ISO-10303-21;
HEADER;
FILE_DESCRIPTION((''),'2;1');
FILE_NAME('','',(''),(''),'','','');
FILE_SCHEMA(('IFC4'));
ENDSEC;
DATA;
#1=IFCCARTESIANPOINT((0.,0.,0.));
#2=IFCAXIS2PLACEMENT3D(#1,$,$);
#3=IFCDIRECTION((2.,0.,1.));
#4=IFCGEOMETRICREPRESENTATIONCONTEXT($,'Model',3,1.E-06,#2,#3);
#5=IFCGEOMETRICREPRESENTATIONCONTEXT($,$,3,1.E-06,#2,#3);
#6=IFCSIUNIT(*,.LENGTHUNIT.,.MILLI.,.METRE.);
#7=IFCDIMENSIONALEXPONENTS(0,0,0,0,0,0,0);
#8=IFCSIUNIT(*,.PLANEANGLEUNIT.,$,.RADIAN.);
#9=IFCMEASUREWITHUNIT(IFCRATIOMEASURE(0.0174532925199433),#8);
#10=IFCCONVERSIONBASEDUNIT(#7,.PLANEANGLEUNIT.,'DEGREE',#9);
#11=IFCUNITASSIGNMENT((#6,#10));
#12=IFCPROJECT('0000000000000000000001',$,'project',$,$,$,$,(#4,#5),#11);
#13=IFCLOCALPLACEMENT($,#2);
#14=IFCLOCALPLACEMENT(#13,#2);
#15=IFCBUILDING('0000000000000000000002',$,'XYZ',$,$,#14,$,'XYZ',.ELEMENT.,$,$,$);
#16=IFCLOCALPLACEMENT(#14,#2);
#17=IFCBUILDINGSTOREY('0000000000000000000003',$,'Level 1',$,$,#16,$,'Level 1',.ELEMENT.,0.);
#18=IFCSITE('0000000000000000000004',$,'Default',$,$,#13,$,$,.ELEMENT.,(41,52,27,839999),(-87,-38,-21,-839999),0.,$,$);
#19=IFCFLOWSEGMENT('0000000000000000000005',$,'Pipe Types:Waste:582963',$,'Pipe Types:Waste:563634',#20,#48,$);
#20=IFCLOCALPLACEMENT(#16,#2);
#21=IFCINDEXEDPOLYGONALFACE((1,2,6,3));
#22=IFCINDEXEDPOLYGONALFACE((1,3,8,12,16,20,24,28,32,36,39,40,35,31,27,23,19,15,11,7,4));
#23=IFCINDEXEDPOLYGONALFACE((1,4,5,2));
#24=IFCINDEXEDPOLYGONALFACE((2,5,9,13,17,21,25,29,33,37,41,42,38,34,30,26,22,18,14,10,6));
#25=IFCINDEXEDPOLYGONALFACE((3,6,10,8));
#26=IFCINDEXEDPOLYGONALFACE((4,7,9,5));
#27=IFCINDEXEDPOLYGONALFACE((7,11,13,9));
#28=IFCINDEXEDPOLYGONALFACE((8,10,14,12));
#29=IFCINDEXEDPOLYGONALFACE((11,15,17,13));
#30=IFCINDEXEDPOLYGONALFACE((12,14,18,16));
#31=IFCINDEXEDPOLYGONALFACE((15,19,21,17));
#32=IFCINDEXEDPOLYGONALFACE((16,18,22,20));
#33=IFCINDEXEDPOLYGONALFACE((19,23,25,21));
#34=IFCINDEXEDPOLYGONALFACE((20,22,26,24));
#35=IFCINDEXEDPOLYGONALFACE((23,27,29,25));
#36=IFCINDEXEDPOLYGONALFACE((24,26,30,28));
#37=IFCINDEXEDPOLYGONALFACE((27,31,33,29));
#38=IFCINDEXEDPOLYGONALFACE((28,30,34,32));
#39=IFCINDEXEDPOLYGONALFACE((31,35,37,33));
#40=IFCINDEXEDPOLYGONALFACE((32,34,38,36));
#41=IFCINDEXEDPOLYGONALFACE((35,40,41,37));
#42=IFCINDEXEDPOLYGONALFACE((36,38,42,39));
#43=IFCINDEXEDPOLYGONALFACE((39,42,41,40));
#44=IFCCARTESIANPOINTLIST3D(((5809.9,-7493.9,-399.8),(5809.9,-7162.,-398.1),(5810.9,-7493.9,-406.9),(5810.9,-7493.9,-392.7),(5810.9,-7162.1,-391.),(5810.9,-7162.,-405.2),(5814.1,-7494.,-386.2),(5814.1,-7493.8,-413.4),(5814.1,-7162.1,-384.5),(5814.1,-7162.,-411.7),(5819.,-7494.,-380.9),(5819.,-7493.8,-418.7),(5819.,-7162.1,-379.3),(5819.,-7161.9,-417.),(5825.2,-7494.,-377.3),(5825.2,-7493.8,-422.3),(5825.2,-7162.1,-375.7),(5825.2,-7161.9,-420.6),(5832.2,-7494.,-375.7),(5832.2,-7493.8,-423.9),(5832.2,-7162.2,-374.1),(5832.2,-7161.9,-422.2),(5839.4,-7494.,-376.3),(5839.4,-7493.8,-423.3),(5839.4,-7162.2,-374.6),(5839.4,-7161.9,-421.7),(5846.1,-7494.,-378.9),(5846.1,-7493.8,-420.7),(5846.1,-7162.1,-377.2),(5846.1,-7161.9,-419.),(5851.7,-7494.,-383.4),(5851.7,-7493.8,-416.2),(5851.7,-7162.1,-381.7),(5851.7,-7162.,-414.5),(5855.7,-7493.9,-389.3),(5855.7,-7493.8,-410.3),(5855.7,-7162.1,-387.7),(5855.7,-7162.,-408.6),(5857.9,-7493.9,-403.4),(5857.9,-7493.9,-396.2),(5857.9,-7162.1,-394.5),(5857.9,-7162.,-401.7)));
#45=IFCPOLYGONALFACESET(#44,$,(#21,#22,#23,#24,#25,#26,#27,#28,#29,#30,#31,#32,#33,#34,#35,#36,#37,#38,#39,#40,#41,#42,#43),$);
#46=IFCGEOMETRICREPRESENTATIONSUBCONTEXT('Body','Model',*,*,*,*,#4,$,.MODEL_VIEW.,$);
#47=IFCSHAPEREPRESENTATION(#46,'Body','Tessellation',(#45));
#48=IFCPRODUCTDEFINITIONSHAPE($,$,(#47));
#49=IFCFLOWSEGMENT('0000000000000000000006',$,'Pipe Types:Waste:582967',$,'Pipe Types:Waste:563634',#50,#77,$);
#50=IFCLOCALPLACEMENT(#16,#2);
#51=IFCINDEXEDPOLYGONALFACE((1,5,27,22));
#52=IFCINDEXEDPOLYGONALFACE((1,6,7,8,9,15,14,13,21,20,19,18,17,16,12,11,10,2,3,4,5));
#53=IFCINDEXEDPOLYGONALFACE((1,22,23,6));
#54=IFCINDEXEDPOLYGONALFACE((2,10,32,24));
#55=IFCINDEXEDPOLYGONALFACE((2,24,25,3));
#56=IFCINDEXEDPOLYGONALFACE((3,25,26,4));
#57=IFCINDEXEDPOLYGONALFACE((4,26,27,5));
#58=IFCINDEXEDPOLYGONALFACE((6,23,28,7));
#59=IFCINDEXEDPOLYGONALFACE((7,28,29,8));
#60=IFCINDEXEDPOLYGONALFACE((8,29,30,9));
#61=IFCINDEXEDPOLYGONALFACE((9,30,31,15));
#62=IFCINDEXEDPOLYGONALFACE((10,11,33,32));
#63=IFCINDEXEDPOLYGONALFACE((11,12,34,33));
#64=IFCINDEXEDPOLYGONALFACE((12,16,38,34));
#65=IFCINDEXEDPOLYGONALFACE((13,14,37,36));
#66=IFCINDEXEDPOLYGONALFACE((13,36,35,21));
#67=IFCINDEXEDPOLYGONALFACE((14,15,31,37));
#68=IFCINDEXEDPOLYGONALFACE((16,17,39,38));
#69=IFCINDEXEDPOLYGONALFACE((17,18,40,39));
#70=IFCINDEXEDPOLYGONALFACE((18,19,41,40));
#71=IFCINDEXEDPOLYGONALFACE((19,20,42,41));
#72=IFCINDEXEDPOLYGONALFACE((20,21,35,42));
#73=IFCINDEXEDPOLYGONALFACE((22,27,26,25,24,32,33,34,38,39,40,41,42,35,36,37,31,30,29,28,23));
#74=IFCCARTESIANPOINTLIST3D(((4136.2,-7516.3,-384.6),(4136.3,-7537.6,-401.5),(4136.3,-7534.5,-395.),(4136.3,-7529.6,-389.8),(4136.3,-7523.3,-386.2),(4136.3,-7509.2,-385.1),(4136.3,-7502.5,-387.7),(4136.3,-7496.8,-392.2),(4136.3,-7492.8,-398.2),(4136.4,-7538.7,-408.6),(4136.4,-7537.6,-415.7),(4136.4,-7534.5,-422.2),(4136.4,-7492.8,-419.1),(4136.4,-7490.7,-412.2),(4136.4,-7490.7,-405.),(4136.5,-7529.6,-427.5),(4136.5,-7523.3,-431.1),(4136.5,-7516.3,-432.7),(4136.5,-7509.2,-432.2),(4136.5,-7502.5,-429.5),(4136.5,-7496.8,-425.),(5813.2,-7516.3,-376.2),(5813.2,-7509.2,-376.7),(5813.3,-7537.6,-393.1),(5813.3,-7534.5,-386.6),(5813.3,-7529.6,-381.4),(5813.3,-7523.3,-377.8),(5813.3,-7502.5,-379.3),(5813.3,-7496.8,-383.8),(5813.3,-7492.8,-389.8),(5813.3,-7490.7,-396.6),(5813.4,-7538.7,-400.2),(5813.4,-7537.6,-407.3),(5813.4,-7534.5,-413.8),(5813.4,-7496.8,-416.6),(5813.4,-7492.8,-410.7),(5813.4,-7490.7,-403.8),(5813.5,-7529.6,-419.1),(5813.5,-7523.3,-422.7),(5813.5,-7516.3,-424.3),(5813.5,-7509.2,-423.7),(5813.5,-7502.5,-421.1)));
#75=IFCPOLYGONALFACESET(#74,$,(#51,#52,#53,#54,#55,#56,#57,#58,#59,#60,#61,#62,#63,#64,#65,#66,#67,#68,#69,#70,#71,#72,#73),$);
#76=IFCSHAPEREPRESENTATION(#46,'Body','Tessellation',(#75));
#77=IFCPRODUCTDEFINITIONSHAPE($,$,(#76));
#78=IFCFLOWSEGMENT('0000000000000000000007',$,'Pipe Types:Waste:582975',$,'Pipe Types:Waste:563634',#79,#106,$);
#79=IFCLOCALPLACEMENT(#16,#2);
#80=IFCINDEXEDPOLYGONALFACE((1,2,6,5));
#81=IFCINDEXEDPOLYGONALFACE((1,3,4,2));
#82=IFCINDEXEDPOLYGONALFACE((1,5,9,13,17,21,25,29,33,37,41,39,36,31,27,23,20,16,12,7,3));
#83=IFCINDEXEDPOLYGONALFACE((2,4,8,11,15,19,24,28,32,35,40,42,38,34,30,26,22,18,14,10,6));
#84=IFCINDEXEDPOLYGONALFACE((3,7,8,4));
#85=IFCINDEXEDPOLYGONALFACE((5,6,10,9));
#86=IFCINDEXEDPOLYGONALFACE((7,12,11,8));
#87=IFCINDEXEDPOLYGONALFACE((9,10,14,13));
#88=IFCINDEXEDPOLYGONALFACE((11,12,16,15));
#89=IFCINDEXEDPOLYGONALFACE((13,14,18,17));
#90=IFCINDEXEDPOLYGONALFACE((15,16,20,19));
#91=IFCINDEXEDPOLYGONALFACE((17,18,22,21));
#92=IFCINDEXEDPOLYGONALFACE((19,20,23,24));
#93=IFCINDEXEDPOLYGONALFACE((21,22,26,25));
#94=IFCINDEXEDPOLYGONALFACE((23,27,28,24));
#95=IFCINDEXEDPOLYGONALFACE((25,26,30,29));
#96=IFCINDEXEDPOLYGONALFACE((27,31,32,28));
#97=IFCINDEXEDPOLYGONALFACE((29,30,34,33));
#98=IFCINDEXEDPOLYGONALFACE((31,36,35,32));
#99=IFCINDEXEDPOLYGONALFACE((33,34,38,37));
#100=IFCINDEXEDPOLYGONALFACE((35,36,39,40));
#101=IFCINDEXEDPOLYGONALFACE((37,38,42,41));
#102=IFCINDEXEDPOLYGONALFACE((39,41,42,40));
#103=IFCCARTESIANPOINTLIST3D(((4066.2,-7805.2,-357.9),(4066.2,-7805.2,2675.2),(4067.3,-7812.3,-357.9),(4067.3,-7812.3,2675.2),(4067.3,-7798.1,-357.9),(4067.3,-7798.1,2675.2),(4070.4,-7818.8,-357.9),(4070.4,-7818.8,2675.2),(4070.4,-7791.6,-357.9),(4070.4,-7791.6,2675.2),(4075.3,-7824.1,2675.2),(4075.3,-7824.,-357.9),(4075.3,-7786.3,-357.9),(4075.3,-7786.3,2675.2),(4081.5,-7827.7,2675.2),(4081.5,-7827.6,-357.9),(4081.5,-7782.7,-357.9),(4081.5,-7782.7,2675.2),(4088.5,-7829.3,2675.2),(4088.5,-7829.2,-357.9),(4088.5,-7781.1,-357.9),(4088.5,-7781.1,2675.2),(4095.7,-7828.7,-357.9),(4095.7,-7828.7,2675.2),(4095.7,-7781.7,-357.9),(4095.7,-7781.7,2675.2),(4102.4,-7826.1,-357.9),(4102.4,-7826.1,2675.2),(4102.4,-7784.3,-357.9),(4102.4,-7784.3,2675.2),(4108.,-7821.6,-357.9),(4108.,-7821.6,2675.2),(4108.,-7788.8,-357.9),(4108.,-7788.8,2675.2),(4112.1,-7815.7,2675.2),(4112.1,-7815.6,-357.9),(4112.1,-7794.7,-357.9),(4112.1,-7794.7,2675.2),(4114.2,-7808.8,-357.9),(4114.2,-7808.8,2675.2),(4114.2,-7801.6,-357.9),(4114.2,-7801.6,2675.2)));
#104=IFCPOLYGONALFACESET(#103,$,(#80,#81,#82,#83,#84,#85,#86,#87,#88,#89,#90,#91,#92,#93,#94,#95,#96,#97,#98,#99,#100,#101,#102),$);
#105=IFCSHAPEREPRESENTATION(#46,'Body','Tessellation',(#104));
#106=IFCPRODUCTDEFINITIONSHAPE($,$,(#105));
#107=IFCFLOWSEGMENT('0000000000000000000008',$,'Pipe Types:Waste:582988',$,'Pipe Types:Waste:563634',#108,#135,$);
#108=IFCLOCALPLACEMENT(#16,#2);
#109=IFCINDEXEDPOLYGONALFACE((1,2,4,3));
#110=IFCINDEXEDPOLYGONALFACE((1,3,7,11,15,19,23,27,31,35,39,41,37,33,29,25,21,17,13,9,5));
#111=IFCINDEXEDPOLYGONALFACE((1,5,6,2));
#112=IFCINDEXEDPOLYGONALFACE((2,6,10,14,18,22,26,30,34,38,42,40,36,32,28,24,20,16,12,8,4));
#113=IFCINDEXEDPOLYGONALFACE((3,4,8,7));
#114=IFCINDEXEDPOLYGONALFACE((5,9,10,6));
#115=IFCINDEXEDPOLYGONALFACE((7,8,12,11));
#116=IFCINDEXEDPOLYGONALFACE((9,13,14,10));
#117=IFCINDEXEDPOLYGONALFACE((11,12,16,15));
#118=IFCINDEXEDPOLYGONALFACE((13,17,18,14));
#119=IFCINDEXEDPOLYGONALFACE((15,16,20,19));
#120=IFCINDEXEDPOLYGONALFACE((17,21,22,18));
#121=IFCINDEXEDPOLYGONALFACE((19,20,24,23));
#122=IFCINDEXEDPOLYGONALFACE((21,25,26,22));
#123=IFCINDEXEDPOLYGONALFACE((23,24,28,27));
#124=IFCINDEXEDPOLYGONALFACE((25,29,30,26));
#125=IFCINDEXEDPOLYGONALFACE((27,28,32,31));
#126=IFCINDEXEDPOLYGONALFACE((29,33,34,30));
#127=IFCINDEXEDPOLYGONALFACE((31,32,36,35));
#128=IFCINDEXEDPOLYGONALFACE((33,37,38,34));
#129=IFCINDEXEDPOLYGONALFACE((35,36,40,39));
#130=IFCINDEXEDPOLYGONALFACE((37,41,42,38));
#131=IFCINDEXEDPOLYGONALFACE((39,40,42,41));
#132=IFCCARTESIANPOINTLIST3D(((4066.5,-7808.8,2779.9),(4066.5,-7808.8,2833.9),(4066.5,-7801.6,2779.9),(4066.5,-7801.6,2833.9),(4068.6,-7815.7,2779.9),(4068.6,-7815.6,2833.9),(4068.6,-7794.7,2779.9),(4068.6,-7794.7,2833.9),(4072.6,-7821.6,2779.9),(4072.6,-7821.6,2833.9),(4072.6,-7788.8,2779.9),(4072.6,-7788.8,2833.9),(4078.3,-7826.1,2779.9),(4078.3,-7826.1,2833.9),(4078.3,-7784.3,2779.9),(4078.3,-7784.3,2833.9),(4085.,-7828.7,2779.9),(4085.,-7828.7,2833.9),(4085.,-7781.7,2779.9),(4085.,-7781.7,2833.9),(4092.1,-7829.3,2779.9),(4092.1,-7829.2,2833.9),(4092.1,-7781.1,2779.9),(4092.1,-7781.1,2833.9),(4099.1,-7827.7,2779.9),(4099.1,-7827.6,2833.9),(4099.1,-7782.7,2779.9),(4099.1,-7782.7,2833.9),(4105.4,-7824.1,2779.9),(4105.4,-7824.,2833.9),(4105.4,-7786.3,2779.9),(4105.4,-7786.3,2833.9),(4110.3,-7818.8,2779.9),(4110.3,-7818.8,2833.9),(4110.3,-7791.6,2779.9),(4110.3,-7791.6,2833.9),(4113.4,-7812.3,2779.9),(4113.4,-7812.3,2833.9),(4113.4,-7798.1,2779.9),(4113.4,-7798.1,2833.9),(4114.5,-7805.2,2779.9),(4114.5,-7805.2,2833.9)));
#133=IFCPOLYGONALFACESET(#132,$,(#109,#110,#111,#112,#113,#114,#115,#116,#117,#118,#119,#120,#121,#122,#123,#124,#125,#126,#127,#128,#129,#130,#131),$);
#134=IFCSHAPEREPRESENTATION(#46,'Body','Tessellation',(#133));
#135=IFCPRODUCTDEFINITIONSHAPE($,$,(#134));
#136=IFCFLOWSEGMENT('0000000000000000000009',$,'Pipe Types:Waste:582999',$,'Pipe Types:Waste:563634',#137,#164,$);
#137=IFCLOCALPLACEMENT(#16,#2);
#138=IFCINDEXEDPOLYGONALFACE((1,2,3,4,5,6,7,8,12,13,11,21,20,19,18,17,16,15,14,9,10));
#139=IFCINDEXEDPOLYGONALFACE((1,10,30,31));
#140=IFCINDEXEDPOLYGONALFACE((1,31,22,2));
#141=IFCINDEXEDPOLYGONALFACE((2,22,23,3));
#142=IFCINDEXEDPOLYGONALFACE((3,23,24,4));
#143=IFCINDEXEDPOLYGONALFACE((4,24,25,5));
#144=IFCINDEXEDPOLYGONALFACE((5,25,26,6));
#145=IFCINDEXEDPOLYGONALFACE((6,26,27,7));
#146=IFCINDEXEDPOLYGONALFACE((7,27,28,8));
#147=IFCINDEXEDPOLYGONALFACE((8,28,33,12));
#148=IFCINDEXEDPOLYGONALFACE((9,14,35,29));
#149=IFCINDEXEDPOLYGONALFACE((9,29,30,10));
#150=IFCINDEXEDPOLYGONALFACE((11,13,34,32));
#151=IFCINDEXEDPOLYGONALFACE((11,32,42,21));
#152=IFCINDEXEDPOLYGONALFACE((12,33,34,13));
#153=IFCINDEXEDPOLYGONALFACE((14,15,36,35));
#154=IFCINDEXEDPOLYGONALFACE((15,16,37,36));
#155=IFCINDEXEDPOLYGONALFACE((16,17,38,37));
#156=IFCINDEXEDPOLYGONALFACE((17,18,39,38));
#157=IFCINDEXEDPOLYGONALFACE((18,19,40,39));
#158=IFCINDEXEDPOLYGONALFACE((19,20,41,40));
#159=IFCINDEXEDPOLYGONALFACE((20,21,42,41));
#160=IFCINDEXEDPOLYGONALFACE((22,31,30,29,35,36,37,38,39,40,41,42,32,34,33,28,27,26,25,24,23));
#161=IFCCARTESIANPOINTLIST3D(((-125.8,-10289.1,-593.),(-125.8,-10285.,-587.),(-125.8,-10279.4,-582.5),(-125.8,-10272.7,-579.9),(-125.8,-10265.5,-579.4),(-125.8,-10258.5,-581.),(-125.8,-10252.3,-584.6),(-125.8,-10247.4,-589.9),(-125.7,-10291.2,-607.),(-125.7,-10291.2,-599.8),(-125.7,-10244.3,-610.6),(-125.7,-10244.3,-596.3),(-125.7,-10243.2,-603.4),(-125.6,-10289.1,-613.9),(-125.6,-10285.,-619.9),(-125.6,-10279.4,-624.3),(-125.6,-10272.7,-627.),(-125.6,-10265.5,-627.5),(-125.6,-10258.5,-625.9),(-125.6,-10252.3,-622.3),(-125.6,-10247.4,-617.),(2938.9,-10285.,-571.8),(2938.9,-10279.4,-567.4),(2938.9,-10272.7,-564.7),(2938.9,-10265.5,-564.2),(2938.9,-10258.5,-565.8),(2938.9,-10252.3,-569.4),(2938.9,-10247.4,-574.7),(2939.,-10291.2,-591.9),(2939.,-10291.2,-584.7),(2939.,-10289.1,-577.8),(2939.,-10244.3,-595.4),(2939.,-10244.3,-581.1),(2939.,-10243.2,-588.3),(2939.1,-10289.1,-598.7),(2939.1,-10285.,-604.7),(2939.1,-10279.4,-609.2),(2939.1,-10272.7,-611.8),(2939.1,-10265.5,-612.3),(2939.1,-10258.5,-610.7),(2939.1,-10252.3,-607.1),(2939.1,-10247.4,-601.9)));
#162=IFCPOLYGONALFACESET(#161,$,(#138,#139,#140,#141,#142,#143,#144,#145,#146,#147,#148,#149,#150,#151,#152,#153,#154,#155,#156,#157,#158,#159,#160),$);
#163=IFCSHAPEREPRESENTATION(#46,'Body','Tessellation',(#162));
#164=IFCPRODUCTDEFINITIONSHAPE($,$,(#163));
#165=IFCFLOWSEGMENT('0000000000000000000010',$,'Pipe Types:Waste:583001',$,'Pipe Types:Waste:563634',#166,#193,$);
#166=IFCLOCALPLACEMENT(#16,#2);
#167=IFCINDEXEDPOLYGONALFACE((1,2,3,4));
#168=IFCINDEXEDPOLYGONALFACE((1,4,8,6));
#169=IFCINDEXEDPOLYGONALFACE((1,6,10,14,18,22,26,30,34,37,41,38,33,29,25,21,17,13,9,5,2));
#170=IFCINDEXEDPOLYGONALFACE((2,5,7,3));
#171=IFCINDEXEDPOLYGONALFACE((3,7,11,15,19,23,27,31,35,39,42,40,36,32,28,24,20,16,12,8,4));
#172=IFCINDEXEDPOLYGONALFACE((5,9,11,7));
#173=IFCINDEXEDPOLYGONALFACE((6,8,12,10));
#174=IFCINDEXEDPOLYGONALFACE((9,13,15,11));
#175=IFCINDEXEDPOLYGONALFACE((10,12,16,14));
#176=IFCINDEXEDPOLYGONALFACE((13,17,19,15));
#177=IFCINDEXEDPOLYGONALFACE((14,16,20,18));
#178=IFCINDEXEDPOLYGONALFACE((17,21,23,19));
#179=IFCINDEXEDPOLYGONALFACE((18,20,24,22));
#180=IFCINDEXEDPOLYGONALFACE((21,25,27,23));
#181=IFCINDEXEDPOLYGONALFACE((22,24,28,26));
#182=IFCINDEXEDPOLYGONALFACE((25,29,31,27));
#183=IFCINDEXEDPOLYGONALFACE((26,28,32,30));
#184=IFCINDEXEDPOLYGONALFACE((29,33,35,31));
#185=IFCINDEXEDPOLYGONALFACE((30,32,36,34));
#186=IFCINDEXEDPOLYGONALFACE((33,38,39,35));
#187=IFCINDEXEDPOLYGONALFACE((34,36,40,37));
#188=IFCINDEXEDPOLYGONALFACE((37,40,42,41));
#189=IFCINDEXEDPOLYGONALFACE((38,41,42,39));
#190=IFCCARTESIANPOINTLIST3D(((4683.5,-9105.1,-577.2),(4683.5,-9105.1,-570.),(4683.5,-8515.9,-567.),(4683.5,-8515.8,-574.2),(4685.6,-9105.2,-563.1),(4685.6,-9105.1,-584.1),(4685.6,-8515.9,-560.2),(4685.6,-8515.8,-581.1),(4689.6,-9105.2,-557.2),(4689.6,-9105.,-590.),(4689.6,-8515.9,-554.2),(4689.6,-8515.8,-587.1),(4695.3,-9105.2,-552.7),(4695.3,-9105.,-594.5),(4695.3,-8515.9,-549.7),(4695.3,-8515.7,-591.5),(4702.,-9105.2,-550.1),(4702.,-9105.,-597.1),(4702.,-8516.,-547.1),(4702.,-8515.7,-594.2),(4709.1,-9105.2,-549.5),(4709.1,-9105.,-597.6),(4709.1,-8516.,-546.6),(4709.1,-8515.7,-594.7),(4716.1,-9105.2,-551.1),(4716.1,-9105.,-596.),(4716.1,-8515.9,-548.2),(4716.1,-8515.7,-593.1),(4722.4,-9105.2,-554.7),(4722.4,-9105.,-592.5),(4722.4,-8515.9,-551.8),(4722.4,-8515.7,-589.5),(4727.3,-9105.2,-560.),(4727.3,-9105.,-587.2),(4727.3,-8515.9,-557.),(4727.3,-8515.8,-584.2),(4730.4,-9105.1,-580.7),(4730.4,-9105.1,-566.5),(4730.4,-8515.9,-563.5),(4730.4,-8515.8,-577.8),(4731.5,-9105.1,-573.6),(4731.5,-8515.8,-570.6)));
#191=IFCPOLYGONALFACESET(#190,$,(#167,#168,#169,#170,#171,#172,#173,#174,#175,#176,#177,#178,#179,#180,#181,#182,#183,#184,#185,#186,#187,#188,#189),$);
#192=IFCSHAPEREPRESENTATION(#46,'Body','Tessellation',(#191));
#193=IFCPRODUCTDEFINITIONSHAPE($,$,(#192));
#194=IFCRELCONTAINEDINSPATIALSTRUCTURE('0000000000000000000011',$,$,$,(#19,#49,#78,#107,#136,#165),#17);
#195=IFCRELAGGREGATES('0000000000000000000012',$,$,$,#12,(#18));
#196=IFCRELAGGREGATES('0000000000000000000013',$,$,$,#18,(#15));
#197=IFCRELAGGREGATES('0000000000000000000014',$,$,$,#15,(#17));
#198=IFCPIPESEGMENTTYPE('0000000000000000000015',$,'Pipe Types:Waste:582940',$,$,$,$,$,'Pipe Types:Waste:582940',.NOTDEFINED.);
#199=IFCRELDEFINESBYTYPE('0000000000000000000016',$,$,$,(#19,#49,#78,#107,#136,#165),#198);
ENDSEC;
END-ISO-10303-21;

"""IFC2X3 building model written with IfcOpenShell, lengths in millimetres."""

from ifc_helpers import new_model, entity, si_unit, converted_unit, direction, frame, frame_2d, origin, origin_2d_with_axis, place, context, subcontext, project, spatial, circle, extrude, type_object, element, save


model = new_model("IFC2X3")

# Units and contexts
model_context = context("Model", 3, precision=1e-06, world=origin(), true_north=direction((2.0, 0.0, 1.0)))
context_of_model = context(None, 3, precision=1e-06, world=origin(), true_north=direction((2.0, 0.0, 1.0)))
body_context = subcontext(model_context, "Body", "Model", "MODEL_VIEW")
ifc_project = project(units=[si_unit("LENGTHUNIT", "METRE", prefix="MILLI"), converted_unit("PLANEANGLEUNIT", "DEGREE", entity("IfcRatioMeasure", 0.0174532925199433), si_unit("PLANEANGLEUNIT", "RADIAN"), dimensions=[0, 0, 0, 0, 0, 0, 0])], contexts=[model_context, context_of_model])

# Site, building, storey
site_placement = place(None, origin())
site = spatial("IfcSite", under=ifc_project, at=site_placement, Name="Default", CompositionType="ELEMENT", RefLatitude=(41, 52, 27, 839999), RefLongitude=(-87, -38, -21, -839999), RefElevation=0.0)
building_placement = place(site_placement, origin())
building = spatial("IfcBuilding", under=site, at=building_placement, Name="XYZ", LongName="XYZ", CompositionType="ELEMENT")
storey_placement = place(building_placement, origin())
storey = spatial("IfcBuildingStorey", under=building, at=storey_placement, Name="Level 1", LongName="Level 1", CompositionType="ELEMENT", Elevation=0.0)

# Flow segments
pipe_segment_type = type_object("IfcPipeSegmentType", Name="Pipe Types:Waste:582940", ElementType="Pipe Types:Waste:582940", PredefinedType="NOTDEFINED")
flow_segment_1_placement = place(storey_placement, origin())
element("IfcFlowSegment", 1, at=flow_segment_1_placement, inside=storey, type_object=pipe_segment_type, Name="Pipe Types:Waste:582963", ObjectType="Pipe Types:Waste:563634", context=body_context, shape_type="SweptSolid", body=[
    extrude(circle(Radius=24.1, at=origin_2d_with_axis()), frame((5834.0, -7493.9, -399.8), z_axis=(0.000002, 0.999987, 0.005035), x_axis=(-1.0, 0.000002, 0.0)), (0.0, 0.0, 1.0), 331.9),
])
flow_segment_2_placement = place(storey_placement, origin())
element("IfcFlowSegment", 2, at=flow_segment_2_placement, inside=storey, type_object=pipe_segment_type, Name="Pipe Types:Waste:582967", ObjectType="Pipe Types:Waste:563634", context=body_context, shape_type="SweptSolid", body=[
    extrude(circle(Radius=24.1, at=frame_2d((0.0, 0.0), x_axis=(1.0, 0.0))), frame((4136.4, -7514.5, -408.6), z_axis=(0.999987, 0.0, 0.005013), x_axis=(0.0, -1.0, 0.0)), (0.0, 0.0, 1.0), 1677.0),
])
flow_segment_3_placement = place(storey_placement, origin())
element("IfcFlowSegment", 3, at=flow_segment_3_placement, inside=storey, type_object=pipe_segment_type, Name="Pipe Types:Waste:582975", ObjectType="Pipe Types:Waste:563634", context=body_context, shape_type="SweptSolid", body=[
    extrude(circle(Radius=24.1, at=frame_2d((0.0, 0.0), x_axis=(1.0, 0.0))), frame((4090.3, -7805.2, -357.9), z_axis=(0.0, -0.000005, 1.0), x_axis=(-1.0, 0.0, 0.0)), (0.0, 0.0, 1.0), 3033.1),
])
flow_segment_4_placement = place(storey_placement, origin())
element("IfcFlowSegment", 4, at=flow_segment_4_placement, inside=storey, type_object=pipe_segment_type, Name="Pipe Types:Waste:582988", ObjectType="Pipe Types:Waste:563634", context=body_context, shape_type="SweptSolid", body=[
    extrude(circle(Radius=24.1, at=frame_2d((0.0, 0.0), x_axis=(1.0, 0.0))), frame((4090.3, -7805.2, 2779.9), z_axis=(0.0, 0.000288, 1.0), x_axis=(1.0, 0.0, 0.0)), (0.0, 0.0, 1.0), 54.0),
])
flow_segment_5_placement = place(storey_placement, origin())
element("IfcFlowSegment", 5, at=flow_segment_5_placement, inside=storey, type_object=pipe_segment_type, Name="Pipe Types:Waste:582999", ObjectType="Pipe Types:Waste:563634", context=body_context, shape_type="SweptSolid", body=[
    extrude(circle(Radius=24.1, at=frame_2d((0.0, 0.0), x_axis=(1.0, 0.0))), frame((-125.7, -10267.3, -603.4), z_axis=(0.999988, 0.0, 0.004954), x_axis=(0.0, 1.0, 0.0)), (0.0, 0.0, 1.0), 3064.7),
])
flow_segment_6_placement = place(storey_placement, origin())
element("IfcFlowSegment", 6, at=flow_segment_6_placement, inside=storey, type_object=pipe_segment_type, Name="Pipe Types:Waste:583001", ObjectType="Pipe Types:Waste:563634", context=body_context, shape_type="SweptSolid", body=[
    extrude(circle(Radius=24.1, at=frame_2d((0.0, 0.0), x_axis=(1.0, 0.0))), frame((4707.3, -9105.1, -573.6), z_axis=(0.0, 0.999988, 0.005), x_axis=(1.0, 0.0, 0.0)), (0.0, 0.0, 1.0), 589.3),
])

save(model, "model.ifc")
